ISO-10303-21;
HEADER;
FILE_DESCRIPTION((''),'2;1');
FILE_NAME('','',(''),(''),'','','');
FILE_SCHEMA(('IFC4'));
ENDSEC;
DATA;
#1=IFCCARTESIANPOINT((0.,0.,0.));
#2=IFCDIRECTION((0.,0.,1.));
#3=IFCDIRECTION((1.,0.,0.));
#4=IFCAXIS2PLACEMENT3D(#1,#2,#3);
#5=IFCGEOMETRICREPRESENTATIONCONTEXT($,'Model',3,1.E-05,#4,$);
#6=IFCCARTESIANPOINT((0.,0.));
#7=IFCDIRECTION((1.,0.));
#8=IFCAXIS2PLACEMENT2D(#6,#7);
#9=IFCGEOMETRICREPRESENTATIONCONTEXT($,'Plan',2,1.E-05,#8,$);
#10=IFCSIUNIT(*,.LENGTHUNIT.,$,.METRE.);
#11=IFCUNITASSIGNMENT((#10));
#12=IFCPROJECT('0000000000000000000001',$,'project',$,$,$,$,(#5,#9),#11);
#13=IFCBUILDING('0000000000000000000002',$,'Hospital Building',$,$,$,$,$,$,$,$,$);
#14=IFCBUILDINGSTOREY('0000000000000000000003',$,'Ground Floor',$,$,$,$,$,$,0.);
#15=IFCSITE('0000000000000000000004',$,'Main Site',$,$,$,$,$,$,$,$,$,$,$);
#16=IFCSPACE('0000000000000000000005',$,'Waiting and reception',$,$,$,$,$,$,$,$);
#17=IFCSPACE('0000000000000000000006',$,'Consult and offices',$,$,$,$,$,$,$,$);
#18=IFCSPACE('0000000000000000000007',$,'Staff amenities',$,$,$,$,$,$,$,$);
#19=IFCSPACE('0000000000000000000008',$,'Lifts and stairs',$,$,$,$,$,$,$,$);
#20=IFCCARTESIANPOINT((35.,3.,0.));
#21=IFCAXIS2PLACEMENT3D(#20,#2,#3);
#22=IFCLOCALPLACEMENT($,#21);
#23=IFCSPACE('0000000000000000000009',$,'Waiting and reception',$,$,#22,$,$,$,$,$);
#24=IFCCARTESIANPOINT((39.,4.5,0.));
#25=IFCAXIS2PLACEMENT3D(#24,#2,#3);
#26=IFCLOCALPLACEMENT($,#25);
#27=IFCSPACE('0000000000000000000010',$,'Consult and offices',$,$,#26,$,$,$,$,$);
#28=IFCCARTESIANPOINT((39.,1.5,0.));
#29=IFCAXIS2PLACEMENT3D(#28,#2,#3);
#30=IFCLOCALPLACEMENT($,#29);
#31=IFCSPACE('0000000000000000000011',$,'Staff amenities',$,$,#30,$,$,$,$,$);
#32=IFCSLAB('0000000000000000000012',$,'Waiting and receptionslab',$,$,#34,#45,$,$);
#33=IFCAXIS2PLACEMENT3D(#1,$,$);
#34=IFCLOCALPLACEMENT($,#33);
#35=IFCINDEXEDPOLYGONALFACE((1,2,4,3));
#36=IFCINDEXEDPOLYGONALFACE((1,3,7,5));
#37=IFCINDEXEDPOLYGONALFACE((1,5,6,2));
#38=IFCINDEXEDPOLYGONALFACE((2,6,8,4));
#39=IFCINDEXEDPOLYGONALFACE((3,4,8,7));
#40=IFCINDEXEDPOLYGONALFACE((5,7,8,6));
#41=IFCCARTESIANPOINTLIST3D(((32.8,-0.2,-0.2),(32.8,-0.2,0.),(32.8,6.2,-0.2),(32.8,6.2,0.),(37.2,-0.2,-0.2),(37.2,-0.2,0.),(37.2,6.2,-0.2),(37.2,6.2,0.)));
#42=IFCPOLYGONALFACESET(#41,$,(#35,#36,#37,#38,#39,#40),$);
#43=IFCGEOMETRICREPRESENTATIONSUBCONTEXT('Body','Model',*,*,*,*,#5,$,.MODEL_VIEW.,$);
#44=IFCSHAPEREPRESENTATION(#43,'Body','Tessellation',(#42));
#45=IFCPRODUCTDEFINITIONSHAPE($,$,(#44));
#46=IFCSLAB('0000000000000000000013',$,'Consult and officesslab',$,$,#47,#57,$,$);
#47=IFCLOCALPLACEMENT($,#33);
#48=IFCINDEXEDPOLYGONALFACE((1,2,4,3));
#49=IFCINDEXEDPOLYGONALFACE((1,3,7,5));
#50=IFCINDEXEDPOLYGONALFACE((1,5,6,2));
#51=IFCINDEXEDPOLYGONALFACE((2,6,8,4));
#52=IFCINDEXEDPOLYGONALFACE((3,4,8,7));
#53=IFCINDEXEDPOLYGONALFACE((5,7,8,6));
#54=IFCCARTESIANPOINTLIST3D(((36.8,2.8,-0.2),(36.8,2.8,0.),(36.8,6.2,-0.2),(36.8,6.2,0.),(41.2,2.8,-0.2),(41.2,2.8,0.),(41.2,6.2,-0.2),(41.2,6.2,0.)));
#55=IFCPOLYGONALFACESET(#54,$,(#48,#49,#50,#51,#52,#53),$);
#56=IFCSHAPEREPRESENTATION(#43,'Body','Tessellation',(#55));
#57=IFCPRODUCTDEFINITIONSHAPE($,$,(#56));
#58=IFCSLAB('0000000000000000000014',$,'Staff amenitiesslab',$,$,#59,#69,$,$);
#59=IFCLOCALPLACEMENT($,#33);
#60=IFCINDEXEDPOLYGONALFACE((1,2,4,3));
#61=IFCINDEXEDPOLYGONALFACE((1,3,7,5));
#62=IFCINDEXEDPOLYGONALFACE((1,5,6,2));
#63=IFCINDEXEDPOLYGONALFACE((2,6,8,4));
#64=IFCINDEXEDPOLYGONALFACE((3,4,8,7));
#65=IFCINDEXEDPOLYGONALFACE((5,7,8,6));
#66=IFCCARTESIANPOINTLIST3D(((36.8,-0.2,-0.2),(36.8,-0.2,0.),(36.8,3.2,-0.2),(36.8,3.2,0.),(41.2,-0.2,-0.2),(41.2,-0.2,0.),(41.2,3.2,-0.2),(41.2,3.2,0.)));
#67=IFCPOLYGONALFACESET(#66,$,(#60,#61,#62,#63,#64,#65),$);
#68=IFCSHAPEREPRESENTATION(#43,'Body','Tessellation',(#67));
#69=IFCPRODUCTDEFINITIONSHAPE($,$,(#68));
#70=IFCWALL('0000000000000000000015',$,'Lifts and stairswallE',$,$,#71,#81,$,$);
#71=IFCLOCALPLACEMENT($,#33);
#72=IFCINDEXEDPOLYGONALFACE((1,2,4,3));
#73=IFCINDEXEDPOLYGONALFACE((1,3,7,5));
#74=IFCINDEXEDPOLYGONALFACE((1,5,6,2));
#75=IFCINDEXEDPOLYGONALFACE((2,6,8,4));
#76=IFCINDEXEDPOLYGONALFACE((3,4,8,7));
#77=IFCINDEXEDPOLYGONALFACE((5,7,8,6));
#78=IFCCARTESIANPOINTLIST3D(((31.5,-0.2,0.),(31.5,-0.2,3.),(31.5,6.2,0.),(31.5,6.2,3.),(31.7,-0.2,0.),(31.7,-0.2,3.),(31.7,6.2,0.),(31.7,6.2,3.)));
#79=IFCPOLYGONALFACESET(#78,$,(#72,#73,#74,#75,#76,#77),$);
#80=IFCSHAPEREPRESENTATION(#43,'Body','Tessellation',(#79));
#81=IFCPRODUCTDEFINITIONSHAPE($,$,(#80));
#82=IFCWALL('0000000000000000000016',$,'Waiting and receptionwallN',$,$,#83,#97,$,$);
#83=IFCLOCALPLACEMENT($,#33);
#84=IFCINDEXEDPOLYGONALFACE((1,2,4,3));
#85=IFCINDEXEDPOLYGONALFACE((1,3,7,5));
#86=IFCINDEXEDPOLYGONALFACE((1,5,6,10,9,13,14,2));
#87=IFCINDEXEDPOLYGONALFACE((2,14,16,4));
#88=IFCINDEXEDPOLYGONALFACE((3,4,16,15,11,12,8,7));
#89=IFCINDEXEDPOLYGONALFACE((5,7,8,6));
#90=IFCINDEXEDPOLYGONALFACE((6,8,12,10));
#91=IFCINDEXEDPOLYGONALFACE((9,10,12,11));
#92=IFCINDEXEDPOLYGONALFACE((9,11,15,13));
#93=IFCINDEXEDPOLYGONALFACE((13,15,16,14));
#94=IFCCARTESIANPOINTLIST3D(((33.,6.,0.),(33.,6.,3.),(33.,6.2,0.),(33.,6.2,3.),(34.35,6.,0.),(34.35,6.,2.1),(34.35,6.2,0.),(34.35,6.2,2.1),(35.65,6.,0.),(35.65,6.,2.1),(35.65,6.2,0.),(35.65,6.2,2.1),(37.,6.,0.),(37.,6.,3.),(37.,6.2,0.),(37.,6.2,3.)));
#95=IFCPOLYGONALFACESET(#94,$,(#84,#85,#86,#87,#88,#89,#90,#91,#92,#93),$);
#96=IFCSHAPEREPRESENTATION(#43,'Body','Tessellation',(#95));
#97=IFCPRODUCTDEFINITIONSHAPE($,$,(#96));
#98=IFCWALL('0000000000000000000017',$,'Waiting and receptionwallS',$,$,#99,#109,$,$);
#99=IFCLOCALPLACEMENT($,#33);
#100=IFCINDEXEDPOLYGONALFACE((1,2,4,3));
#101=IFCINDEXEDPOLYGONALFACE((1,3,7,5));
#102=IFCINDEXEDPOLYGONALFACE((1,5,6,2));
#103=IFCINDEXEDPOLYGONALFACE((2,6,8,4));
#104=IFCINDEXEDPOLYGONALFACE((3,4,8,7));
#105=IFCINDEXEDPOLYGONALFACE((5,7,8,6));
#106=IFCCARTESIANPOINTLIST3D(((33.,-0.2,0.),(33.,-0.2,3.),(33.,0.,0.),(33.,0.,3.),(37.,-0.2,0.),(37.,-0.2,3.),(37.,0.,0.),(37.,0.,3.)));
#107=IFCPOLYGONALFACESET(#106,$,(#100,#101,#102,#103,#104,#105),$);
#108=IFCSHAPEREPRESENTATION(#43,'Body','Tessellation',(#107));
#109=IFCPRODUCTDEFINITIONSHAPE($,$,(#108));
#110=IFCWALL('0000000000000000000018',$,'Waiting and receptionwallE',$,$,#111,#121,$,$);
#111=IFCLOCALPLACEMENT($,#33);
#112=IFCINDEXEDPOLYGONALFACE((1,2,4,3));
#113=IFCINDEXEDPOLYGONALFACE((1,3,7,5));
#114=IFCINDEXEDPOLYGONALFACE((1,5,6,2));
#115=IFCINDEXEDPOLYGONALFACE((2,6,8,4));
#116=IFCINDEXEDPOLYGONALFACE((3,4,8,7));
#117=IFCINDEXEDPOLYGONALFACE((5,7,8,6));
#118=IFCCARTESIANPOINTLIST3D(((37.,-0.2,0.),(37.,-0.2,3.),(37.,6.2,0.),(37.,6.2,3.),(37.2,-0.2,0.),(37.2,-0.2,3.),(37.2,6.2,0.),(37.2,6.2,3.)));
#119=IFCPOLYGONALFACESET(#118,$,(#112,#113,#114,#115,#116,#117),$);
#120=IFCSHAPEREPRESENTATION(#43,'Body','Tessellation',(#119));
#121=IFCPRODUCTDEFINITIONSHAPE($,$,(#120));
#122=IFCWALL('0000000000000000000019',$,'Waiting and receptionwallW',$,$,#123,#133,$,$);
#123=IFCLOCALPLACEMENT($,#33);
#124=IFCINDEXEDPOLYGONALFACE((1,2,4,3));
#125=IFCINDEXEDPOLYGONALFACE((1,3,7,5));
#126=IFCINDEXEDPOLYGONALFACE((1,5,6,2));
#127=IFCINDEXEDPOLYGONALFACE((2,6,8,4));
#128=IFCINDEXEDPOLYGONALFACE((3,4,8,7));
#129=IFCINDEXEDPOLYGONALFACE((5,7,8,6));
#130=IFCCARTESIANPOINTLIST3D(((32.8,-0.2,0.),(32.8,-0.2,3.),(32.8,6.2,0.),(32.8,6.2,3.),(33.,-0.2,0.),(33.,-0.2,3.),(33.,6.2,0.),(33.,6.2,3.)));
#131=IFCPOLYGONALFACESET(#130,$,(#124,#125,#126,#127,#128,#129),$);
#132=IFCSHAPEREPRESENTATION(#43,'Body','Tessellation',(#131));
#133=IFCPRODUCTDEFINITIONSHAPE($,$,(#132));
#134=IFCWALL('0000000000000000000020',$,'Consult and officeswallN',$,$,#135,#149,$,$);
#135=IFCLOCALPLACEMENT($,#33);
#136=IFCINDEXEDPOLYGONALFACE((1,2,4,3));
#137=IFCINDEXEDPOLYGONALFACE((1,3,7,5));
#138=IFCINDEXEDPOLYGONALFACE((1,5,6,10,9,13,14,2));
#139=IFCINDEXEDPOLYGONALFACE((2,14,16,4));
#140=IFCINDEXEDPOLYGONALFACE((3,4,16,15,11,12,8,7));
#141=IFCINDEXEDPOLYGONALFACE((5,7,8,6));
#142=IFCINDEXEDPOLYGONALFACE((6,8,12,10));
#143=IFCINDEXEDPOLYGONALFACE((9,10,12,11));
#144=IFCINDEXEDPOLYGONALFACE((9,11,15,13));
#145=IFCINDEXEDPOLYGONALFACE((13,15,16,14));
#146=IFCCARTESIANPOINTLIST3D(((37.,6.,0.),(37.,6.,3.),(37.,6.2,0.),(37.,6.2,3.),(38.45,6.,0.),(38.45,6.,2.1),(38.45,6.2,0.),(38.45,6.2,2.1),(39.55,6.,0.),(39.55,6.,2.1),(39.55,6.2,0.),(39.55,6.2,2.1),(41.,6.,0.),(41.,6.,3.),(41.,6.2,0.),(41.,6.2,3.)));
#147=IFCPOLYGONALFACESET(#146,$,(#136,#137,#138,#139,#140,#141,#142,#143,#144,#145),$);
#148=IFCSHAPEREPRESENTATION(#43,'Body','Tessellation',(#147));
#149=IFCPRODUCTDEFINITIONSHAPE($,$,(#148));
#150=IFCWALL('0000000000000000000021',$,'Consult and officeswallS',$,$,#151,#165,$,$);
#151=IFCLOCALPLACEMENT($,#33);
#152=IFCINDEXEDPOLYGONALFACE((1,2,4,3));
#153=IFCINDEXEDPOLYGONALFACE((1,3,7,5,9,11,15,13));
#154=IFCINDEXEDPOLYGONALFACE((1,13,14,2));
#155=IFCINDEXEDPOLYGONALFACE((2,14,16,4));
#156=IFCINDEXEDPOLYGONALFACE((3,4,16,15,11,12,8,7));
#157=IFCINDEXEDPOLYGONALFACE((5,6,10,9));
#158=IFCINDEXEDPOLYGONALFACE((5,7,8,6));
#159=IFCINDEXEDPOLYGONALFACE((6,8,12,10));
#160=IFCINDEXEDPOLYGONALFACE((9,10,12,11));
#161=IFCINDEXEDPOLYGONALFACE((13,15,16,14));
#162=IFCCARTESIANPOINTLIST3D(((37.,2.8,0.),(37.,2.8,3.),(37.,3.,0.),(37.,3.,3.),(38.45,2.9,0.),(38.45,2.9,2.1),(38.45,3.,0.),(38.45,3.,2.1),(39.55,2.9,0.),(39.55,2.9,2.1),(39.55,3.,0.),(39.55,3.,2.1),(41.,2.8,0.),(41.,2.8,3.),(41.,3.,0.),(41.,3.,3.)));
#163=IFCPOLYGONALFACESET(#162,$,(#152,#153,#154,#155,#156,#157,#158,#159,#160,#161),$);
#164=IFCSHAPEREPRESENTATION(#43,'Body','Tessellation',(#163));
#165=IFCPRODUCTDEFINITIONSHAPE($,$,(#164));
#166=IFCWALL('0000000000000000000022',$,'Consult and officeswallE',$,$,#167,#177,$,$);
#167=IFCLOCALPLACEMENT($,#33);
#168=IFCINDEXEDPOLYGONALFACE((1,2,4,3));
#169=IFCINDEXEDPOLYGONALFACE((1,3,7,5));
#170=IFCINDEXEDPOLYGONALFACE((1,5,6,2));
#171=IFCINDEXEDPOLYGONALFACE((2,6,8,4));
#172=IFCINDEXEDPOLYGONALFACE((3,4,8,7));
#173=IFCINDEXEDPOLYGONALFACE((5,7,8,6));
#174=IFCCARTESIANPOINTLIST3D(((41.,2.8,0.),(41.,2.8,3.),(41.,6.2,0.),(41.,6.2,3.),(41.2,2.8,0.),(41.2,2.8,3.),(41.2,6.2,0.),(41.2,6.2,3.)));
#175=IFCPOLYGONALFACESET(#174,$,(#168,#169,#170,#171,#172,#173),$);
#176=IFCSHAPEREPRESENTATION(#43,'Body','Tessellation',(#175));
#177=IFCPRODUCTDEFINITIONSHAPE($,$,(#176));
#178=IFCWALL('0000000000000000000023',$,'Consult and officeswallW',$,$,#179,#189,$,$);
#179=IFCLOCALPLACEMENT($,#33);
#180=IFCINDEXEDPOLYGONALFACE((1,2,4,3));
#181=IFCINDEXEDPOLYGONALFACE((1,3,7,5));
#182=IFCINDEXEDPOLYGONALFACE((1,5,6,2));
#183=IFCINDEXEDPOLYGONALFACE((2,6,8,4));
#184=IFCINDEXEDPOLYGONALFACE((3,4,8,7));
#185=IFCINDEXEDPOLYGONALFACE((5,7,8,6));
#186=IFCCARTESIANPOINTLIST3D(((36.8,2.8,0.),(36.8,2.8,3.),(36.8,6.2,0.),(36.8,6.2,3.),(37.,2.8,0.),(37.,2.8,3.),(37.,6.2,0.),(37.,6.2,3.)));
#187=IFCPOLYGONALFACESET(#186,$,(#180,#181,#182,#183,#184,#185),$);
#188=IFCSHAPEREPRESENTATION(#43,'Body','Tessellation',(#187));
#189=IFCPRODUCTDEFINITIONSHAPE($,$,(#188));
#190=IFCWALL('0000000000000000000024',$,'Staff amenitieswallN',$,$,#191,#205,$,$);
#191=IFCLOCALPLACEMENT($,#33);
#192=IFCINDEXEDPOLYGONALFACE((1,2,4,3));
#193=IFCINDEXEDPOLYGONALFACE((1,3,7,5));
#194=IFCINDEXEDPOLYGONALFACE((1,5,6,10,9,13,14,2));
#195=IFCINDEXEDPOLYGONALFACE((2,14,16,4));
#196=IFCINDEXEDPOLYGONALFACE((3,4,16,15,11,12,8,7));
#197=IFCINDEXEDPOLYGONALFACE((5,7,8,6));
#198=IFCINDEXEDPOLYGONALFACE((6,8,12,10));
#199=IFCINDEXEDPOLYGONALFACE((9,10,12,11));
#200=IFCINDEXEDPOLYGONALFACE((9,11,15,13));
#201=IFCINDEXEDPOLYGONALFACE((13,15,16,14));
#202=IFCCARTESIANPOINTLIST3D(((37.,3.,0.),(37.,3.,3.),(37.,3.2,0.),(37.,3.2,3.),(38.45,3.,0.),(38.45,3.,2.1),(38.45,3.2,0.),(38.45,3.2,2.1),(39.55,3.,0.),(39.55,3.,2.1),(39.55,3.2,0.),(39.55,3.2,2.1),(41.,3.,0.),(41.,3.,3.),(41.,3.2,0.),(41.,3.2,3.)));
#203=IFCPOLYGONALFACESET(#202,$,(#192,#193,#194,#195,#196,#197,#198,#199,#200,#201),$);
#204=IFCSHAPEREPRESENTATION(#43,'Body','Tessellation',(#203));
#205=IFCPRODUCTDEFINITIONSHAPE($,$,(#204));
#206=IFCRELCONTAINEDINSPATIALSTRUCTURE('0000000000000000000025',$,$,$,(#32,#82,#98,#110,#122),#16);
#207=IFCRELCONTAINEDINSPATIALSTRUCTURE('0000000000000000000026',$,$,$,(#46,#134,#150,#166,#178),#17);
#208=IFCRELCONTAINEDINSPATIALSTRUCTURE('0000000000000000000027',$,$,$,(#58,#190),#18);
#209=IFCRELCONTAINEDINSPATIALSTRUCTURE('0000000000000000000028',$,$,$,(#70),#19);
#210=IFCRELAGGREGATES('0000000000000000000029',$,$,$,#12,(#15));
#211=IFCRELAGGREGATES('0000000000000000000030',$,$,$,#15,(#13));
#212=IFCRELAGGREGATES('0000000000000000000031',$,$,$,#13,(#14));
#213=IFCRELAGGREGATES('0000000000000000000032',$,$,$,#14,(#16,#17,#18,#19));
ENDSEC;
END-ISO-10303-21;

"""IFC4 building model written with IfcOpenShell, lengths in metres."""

from ifc_helpers import new_model, si_unit, frame, origin_with_axes, origin_2d_with_axis, place, context, subcontext, project, spatial, indexed_curve, rectangle, outline, extrude, element, save


model = new_model("IFC4")

# Units and contexts
model_context = context("Model", 3, precision=1e-05, world=origin_with_axes())
plan_context = context("Plan", 2, precision=1e-05, world=origin_2d_with_axis())
body_context = subcontext(model_context, "Body", "Model", "MODEL_VIEW")
ifc_project = project(units=[si_unit("LENGTHUNIT", "METRE")], contexts=[model_context, plan_context])

# Site, building, storey, space
site = spatial("IfcSite", under=ifc_project, Name="Main Site")
building = spatial("IfcBuilding", under=site, Name="Hospital Building")
storey = spatial("IfcBuildingStorey", under=building, Name="Ground Floor", Elevation=0.0)
space_1 = spatial("IfcSpace", under=storey, Name="Waiting and reception")

# Slab
slab_1_placement = place(None, frame((35.0, 3.0, -0.2), z_axis=(0.0, 0.0, 1.0), x_axis=(1.0, 0.0, 0.0)))
element("IfcSlab", 1, at=slab_1_placement, inside=space_1, Name="Waiting and receptionslab", context=body_context, shape_type="SweptSolid", body=[
    extrude(rectangle(XDim=4.4, YDim=6.4), origin_with_axes(), (0.0, 0.0, 1.0), 0.2),
])

# Shared definitions
space_2 = spatial("IfcSpace", under=storey, Name="Consult and offices")

# Slab
slab_2_placement = place(None, frame((39.0, 4.5, -0.2), z_axis=(0.0, 0.0, 1.0), x_axis=(1.0, 0.0, 0.0)))
element("IfcSlab", 2, at=slab_2_placement, inside=space_2, Name="Consult and officesslab", context=body_context, shape_type="SweptSolid", body=[
    extrude(rectangle(XDim=4.4, YDim=3.4), origin_with_axes(), (0.0, 0.0, 1.0), 0.2),
])

# Shared definitions
space_3 = spatial("IfcSpace", under=storey, Name="Staff amenities")

# Slab
slab_3_placement = place(None, frame((39.0, 1.5, -0.2), z_axis=(0.0, 0.0, 1.0), x_axis=(1.0, 0.0, 0.0)))
element("IfcSlab", 3, at=slab_3_placement, inside=space_3, Name="Staff amenitiesslab", context=body_context, shape_type="SweptSolid", body=[
    extrude(rectangle(XDim=4.4, YDim=3.4), origin_with_axes(), (0.0, 0.0, 1.0), 0.2),
])

# Shared definitions
space_4 = spatial("IfcSpace", under=storey, Name="Lifts and stairs")

# Walls
wall_1_placement = place(None, frame((31.7, -0.2, 0.0), z_axis=(0.0, 0.0, 1.0), x_axis=(0.0, 1.0, 0.0)))
element("IfcWall", 4, at=wall_1_placement, inside=space_4, Name="Lifts and stairswallE", context=body_context, shape_type="SweptSolid", body=[
    extrude(outline(indexed_curve([(0.0, 0.0), (0.0, 0.2), (6.4, 0.2), (6.4, 0.0), (0.0, 0.0)], self_intersect=False)), origin_with_axes(), (0.0, 0.0, 1.0), 3.0),
])
wall_2_placement = place(None, frame((33.0, 6.0, 0.0), z_axis=(0.0, 0.0, 1.0), x_axis=(1.0, 0.0, 0.0)))
wall_2 = element("IfcWall", 5, at=wall_2_placement, inside=space_1, Name="Waiting and receptionwallN", context=body_context, shape_type="SweptSolid", body=[
    extrude(outline(indexed_curve([(0.0, 0.0), (0.0, 0.2), (4.0, 0.2), (4.0, 0.0), (0.0, 0.0)], self_intersect=False)), origin_with_axes(), (0.0, 0.0, 1.0), 3.0),
])

# Shared definitions
space_5_placement = place(None, frame((35.0, 3.0, 0.0), z_axis=(0.0, 0.0, 1.0), x_axis=(1.0, 0.0, 0.0)))
space_5 = spatial("IfcSpace", at=space_5_placement, Name="Waiting and reception")

# Opening
opening_1_placement = place(wall_2_placement, frame((1.35, -0.1, 0.0), z_axis=(0.0, 0.0, 1.0), x_axis=(1.0, 0.0, 0.0)))
element("IfcOpeningElement", 6, at=opening_1_placement, inside=space_5, cuts=wall_2, context=body_context, shape_type="SweptSolid", body=[
    extrude(outline(indexed_curve([(0.0, 0.0), (0.0, 0.4), (1.3, 0.4), (1.3, 0.0), (0.0, 0.0)], self_intersect=False)), origin_with_axes(), (0.0, 0.0, 1.0), 2.1),
])

# Walls
wall_3_placement = place(None, frame((33.0, -0.2, 0.0), z_axis=(0.0, 0.0, 1.0), x_axis=(1.0, 0.0, 0.0)))
element("IfcWall", 7, at=wall_3_placement, inside=space_1, Name="Waiting and receptionwallS", context=body_context, shape_type="SweptSolid", body=[
    extrude(outline(indexed_curve([(0.0, 0.0), (0.0, 0.2), (4.0, 0.2), (4.0, 0.0), (0.0, 0.0)], self_intersect=False)), origin_with_axes(), (0.0, 0.0, 1.0), 3.0),
])
for number, where, z_axis, x_axis, name in (
    (8, (37.2, -0.2, 0.0), (0.0, 0.0, 1.0), (0.0, 1.0, 0.0), "Waiting and receptionwallE"),
    (9, (33.0, -0.2, 0.0), (0.0, 0.0, 1.0), (0.0, 1.0, 0.0), "Waiting and receptionwallW"),
):
    element("IfcWall", number, at=place(None, frame(where, z_axis=z_axis, x_axis=x_axis)), inside=space_1, Name=name, context=body_context, shape_type="SweptSolid", body=[
        extrude(outline(indexed_curve([(0.0, 0.0), (0.0, 0.2), (6.4, 0.2), (6.4, 0.0), (0.0, 0.0)], self_intersect=False)), origin_with_axes(), (0.0, 0.0, 1.0), 3.0),
    ])

# Wall
wall_4_placement = place(None, frame((37.0, 6.0, 0.0), z_axis=(0.0, 0.0, 1.0), x_axis=(1.0, 0.0, 0.0)))
wall_4 = element("IfcWall", 10, at=wall_4_placement, inside=space_2, Name="Consult and officeswallN", context=body_context, shape_type="SweptSolid", body=[
    extrude(outline(indexed_curve([(0.0, 0.0), (0.0, 0.2), (4.0, 0.2), (4.0, 0.0), (0.0, 0.0)], self_intersect=False)), origin_with_axes(), (0.0, 0.0, 1.0), 3.0),
])

# Shared definitions
space_6_placement = place(None, frame((39.0, 4.5, 0.0), z_axis=(0.0, 0.0, 1.0), x_axis=(1.0, 0.0, 0.0)))
space_6 = spatial("IfcSpace", at=space_6_placement, Name="Consult and offices")

# Opening
opening_2_placement = place(wall_4_placement, frame((1.45, -0.1, 0.0), z_axis=(0.0, 0.0, 1.0), x_axis=(1.0, 0.0, 0.0)))
element("IfcOpeningElement", 11, at=opening_2_placement, inside=space_6, cuts=wall_4, context=body_context, shape_type="SweptSolid", body=[
    extrude(outline(indexed_curve([(0.0, 0.0), (0.0, 0.4), (1.1, 0.4), (1.1, 0.0), (0.0, 0.0)], self_intersect=False)), origin_with_axes(), (0.0, 0.0, 1.0), 2.1),
])

# Wall, opening
wall_5_placement = place(None, frame((37.0, 2.8, 0.0), z_axis=(0.0, 0.0, 1.0), x_axis=(1.0, 0.0, 0.0)))
wall_5 = element("IfcWall", 12, at=wall_5_placement, inside=space_2, Name="Consult and officeswallS", context=body_context, shape_type="SweptSolid", body=[
    extrude(outline(indexed_curve([(0.0, 0.0), (0.0, 0.2), (4.0, 0.2), (4.0, 0.0), (0.0, 0.0)], self_intersect=False)), origin_with_axes(), (0.0, 0.0, 1.0), 3.0),
])
opening_3_placement = place(wall_5_placement, frame((1.45, 0.1, 0.0), z_axis=(0.0, 0.0, 1.0), x_axis=(1.0, 0.0, 0.0)))
element("IfcOpeningElement", 13, at=opening_3_placement, inside=space_6, cuts=wall_5, context=body_context, shape_type="SweptSolid", body=[
    extrude(outline(indexed_curve([(0.0, 0.0), (0.0, 0.4), (1.1, 0.4), (1.1, 0.0), (0.0, 0.0)], self_intersect=False)), origin_with_axes(), (0.0, 0.0, 1.0), 2.1),
])

# Walls
for number, where, z_axis, x_axis, name in (
    (14, (41.2, 2.8, 0.0), (0.0, 0.0, 1.0), (0.0, 1.0, 0.0), "Consult and officeswallE"),
    (15, (37.0, 2.8, 0.0), (0.0, 0.0, 1.0), (0.0, 1.0, 0.0), "Consult and officeswallW"),
):
    element("IfcWall", number, at=place(None, frame(where, z_axis=z_axis, x_axis=x_axis)), inside=space_2, Name=name, context=body_context, shape_type="SweptSolid", body=[
        extrude(outline(indexed_curve([(0.0, 0.0), (0.0, 0.2), (3.4, 0.2), (3.4, 0.0), (0.0, 0.0)], self_intersect=False)), origin_with_axes(), (0.0, 0.0, 1.0), 3.0),
    ])

# Wall
wall_6_placement = place(None, frame((37.0, 3.0, 0.0), z_axis=(0.0, 0.0, 1.0), x_axis=(1.0, 0.0, 0.0)))
wall_6 = element("IfcWall", 16, at=wall_6_placement, inside=space_3, Name="Staff amenitieswallN", context=body_context, shape_type="SweptSolid", body=[
    extrude(outline(indexed_curve([(0.0, 0.0), (0.0, 0.2), (4.0, 0.2), (4.0, 0.0), (0.0, 0.0)], self_intersect=False)), origin_with_axes(), (0.0, 0.0, 1.0), 3.0),
])

# Shared definitions
space_7_placement = place(None, frame((39.0, 1.5, 0.0), z_axis=(0.0, 0.0, 1.0), x_axis=(1.0, 0.0, 0.0)))
space_7 = spatial("IfcSpace", at=space_7_placement, Name="Staff amenities")

# Opening
opening_4_placement = place(wall_6_placement, frame((1.45, -0.1, 0.0), z_axis=(0.0, 0.0, 1.0), x_axis=(1.0, 0.0, 0.0)))
element("IfcOpeningElement", 17, at=opening_4_placement, inside=space_7, cuts=wall_6, context=body_context, shape_type="SweptSolid", body=[
    extrude(outline(indexed_curve([(0.0, 0.0), (0.0, 0.4), (1.1, 0.4), (1.1, 0.0), (0.0, 0.0)], self_intersect=False)), origin_with_axes(), (0.0, 0.0, 1.0), 2.1),
])

save(model, "model.ifc")
